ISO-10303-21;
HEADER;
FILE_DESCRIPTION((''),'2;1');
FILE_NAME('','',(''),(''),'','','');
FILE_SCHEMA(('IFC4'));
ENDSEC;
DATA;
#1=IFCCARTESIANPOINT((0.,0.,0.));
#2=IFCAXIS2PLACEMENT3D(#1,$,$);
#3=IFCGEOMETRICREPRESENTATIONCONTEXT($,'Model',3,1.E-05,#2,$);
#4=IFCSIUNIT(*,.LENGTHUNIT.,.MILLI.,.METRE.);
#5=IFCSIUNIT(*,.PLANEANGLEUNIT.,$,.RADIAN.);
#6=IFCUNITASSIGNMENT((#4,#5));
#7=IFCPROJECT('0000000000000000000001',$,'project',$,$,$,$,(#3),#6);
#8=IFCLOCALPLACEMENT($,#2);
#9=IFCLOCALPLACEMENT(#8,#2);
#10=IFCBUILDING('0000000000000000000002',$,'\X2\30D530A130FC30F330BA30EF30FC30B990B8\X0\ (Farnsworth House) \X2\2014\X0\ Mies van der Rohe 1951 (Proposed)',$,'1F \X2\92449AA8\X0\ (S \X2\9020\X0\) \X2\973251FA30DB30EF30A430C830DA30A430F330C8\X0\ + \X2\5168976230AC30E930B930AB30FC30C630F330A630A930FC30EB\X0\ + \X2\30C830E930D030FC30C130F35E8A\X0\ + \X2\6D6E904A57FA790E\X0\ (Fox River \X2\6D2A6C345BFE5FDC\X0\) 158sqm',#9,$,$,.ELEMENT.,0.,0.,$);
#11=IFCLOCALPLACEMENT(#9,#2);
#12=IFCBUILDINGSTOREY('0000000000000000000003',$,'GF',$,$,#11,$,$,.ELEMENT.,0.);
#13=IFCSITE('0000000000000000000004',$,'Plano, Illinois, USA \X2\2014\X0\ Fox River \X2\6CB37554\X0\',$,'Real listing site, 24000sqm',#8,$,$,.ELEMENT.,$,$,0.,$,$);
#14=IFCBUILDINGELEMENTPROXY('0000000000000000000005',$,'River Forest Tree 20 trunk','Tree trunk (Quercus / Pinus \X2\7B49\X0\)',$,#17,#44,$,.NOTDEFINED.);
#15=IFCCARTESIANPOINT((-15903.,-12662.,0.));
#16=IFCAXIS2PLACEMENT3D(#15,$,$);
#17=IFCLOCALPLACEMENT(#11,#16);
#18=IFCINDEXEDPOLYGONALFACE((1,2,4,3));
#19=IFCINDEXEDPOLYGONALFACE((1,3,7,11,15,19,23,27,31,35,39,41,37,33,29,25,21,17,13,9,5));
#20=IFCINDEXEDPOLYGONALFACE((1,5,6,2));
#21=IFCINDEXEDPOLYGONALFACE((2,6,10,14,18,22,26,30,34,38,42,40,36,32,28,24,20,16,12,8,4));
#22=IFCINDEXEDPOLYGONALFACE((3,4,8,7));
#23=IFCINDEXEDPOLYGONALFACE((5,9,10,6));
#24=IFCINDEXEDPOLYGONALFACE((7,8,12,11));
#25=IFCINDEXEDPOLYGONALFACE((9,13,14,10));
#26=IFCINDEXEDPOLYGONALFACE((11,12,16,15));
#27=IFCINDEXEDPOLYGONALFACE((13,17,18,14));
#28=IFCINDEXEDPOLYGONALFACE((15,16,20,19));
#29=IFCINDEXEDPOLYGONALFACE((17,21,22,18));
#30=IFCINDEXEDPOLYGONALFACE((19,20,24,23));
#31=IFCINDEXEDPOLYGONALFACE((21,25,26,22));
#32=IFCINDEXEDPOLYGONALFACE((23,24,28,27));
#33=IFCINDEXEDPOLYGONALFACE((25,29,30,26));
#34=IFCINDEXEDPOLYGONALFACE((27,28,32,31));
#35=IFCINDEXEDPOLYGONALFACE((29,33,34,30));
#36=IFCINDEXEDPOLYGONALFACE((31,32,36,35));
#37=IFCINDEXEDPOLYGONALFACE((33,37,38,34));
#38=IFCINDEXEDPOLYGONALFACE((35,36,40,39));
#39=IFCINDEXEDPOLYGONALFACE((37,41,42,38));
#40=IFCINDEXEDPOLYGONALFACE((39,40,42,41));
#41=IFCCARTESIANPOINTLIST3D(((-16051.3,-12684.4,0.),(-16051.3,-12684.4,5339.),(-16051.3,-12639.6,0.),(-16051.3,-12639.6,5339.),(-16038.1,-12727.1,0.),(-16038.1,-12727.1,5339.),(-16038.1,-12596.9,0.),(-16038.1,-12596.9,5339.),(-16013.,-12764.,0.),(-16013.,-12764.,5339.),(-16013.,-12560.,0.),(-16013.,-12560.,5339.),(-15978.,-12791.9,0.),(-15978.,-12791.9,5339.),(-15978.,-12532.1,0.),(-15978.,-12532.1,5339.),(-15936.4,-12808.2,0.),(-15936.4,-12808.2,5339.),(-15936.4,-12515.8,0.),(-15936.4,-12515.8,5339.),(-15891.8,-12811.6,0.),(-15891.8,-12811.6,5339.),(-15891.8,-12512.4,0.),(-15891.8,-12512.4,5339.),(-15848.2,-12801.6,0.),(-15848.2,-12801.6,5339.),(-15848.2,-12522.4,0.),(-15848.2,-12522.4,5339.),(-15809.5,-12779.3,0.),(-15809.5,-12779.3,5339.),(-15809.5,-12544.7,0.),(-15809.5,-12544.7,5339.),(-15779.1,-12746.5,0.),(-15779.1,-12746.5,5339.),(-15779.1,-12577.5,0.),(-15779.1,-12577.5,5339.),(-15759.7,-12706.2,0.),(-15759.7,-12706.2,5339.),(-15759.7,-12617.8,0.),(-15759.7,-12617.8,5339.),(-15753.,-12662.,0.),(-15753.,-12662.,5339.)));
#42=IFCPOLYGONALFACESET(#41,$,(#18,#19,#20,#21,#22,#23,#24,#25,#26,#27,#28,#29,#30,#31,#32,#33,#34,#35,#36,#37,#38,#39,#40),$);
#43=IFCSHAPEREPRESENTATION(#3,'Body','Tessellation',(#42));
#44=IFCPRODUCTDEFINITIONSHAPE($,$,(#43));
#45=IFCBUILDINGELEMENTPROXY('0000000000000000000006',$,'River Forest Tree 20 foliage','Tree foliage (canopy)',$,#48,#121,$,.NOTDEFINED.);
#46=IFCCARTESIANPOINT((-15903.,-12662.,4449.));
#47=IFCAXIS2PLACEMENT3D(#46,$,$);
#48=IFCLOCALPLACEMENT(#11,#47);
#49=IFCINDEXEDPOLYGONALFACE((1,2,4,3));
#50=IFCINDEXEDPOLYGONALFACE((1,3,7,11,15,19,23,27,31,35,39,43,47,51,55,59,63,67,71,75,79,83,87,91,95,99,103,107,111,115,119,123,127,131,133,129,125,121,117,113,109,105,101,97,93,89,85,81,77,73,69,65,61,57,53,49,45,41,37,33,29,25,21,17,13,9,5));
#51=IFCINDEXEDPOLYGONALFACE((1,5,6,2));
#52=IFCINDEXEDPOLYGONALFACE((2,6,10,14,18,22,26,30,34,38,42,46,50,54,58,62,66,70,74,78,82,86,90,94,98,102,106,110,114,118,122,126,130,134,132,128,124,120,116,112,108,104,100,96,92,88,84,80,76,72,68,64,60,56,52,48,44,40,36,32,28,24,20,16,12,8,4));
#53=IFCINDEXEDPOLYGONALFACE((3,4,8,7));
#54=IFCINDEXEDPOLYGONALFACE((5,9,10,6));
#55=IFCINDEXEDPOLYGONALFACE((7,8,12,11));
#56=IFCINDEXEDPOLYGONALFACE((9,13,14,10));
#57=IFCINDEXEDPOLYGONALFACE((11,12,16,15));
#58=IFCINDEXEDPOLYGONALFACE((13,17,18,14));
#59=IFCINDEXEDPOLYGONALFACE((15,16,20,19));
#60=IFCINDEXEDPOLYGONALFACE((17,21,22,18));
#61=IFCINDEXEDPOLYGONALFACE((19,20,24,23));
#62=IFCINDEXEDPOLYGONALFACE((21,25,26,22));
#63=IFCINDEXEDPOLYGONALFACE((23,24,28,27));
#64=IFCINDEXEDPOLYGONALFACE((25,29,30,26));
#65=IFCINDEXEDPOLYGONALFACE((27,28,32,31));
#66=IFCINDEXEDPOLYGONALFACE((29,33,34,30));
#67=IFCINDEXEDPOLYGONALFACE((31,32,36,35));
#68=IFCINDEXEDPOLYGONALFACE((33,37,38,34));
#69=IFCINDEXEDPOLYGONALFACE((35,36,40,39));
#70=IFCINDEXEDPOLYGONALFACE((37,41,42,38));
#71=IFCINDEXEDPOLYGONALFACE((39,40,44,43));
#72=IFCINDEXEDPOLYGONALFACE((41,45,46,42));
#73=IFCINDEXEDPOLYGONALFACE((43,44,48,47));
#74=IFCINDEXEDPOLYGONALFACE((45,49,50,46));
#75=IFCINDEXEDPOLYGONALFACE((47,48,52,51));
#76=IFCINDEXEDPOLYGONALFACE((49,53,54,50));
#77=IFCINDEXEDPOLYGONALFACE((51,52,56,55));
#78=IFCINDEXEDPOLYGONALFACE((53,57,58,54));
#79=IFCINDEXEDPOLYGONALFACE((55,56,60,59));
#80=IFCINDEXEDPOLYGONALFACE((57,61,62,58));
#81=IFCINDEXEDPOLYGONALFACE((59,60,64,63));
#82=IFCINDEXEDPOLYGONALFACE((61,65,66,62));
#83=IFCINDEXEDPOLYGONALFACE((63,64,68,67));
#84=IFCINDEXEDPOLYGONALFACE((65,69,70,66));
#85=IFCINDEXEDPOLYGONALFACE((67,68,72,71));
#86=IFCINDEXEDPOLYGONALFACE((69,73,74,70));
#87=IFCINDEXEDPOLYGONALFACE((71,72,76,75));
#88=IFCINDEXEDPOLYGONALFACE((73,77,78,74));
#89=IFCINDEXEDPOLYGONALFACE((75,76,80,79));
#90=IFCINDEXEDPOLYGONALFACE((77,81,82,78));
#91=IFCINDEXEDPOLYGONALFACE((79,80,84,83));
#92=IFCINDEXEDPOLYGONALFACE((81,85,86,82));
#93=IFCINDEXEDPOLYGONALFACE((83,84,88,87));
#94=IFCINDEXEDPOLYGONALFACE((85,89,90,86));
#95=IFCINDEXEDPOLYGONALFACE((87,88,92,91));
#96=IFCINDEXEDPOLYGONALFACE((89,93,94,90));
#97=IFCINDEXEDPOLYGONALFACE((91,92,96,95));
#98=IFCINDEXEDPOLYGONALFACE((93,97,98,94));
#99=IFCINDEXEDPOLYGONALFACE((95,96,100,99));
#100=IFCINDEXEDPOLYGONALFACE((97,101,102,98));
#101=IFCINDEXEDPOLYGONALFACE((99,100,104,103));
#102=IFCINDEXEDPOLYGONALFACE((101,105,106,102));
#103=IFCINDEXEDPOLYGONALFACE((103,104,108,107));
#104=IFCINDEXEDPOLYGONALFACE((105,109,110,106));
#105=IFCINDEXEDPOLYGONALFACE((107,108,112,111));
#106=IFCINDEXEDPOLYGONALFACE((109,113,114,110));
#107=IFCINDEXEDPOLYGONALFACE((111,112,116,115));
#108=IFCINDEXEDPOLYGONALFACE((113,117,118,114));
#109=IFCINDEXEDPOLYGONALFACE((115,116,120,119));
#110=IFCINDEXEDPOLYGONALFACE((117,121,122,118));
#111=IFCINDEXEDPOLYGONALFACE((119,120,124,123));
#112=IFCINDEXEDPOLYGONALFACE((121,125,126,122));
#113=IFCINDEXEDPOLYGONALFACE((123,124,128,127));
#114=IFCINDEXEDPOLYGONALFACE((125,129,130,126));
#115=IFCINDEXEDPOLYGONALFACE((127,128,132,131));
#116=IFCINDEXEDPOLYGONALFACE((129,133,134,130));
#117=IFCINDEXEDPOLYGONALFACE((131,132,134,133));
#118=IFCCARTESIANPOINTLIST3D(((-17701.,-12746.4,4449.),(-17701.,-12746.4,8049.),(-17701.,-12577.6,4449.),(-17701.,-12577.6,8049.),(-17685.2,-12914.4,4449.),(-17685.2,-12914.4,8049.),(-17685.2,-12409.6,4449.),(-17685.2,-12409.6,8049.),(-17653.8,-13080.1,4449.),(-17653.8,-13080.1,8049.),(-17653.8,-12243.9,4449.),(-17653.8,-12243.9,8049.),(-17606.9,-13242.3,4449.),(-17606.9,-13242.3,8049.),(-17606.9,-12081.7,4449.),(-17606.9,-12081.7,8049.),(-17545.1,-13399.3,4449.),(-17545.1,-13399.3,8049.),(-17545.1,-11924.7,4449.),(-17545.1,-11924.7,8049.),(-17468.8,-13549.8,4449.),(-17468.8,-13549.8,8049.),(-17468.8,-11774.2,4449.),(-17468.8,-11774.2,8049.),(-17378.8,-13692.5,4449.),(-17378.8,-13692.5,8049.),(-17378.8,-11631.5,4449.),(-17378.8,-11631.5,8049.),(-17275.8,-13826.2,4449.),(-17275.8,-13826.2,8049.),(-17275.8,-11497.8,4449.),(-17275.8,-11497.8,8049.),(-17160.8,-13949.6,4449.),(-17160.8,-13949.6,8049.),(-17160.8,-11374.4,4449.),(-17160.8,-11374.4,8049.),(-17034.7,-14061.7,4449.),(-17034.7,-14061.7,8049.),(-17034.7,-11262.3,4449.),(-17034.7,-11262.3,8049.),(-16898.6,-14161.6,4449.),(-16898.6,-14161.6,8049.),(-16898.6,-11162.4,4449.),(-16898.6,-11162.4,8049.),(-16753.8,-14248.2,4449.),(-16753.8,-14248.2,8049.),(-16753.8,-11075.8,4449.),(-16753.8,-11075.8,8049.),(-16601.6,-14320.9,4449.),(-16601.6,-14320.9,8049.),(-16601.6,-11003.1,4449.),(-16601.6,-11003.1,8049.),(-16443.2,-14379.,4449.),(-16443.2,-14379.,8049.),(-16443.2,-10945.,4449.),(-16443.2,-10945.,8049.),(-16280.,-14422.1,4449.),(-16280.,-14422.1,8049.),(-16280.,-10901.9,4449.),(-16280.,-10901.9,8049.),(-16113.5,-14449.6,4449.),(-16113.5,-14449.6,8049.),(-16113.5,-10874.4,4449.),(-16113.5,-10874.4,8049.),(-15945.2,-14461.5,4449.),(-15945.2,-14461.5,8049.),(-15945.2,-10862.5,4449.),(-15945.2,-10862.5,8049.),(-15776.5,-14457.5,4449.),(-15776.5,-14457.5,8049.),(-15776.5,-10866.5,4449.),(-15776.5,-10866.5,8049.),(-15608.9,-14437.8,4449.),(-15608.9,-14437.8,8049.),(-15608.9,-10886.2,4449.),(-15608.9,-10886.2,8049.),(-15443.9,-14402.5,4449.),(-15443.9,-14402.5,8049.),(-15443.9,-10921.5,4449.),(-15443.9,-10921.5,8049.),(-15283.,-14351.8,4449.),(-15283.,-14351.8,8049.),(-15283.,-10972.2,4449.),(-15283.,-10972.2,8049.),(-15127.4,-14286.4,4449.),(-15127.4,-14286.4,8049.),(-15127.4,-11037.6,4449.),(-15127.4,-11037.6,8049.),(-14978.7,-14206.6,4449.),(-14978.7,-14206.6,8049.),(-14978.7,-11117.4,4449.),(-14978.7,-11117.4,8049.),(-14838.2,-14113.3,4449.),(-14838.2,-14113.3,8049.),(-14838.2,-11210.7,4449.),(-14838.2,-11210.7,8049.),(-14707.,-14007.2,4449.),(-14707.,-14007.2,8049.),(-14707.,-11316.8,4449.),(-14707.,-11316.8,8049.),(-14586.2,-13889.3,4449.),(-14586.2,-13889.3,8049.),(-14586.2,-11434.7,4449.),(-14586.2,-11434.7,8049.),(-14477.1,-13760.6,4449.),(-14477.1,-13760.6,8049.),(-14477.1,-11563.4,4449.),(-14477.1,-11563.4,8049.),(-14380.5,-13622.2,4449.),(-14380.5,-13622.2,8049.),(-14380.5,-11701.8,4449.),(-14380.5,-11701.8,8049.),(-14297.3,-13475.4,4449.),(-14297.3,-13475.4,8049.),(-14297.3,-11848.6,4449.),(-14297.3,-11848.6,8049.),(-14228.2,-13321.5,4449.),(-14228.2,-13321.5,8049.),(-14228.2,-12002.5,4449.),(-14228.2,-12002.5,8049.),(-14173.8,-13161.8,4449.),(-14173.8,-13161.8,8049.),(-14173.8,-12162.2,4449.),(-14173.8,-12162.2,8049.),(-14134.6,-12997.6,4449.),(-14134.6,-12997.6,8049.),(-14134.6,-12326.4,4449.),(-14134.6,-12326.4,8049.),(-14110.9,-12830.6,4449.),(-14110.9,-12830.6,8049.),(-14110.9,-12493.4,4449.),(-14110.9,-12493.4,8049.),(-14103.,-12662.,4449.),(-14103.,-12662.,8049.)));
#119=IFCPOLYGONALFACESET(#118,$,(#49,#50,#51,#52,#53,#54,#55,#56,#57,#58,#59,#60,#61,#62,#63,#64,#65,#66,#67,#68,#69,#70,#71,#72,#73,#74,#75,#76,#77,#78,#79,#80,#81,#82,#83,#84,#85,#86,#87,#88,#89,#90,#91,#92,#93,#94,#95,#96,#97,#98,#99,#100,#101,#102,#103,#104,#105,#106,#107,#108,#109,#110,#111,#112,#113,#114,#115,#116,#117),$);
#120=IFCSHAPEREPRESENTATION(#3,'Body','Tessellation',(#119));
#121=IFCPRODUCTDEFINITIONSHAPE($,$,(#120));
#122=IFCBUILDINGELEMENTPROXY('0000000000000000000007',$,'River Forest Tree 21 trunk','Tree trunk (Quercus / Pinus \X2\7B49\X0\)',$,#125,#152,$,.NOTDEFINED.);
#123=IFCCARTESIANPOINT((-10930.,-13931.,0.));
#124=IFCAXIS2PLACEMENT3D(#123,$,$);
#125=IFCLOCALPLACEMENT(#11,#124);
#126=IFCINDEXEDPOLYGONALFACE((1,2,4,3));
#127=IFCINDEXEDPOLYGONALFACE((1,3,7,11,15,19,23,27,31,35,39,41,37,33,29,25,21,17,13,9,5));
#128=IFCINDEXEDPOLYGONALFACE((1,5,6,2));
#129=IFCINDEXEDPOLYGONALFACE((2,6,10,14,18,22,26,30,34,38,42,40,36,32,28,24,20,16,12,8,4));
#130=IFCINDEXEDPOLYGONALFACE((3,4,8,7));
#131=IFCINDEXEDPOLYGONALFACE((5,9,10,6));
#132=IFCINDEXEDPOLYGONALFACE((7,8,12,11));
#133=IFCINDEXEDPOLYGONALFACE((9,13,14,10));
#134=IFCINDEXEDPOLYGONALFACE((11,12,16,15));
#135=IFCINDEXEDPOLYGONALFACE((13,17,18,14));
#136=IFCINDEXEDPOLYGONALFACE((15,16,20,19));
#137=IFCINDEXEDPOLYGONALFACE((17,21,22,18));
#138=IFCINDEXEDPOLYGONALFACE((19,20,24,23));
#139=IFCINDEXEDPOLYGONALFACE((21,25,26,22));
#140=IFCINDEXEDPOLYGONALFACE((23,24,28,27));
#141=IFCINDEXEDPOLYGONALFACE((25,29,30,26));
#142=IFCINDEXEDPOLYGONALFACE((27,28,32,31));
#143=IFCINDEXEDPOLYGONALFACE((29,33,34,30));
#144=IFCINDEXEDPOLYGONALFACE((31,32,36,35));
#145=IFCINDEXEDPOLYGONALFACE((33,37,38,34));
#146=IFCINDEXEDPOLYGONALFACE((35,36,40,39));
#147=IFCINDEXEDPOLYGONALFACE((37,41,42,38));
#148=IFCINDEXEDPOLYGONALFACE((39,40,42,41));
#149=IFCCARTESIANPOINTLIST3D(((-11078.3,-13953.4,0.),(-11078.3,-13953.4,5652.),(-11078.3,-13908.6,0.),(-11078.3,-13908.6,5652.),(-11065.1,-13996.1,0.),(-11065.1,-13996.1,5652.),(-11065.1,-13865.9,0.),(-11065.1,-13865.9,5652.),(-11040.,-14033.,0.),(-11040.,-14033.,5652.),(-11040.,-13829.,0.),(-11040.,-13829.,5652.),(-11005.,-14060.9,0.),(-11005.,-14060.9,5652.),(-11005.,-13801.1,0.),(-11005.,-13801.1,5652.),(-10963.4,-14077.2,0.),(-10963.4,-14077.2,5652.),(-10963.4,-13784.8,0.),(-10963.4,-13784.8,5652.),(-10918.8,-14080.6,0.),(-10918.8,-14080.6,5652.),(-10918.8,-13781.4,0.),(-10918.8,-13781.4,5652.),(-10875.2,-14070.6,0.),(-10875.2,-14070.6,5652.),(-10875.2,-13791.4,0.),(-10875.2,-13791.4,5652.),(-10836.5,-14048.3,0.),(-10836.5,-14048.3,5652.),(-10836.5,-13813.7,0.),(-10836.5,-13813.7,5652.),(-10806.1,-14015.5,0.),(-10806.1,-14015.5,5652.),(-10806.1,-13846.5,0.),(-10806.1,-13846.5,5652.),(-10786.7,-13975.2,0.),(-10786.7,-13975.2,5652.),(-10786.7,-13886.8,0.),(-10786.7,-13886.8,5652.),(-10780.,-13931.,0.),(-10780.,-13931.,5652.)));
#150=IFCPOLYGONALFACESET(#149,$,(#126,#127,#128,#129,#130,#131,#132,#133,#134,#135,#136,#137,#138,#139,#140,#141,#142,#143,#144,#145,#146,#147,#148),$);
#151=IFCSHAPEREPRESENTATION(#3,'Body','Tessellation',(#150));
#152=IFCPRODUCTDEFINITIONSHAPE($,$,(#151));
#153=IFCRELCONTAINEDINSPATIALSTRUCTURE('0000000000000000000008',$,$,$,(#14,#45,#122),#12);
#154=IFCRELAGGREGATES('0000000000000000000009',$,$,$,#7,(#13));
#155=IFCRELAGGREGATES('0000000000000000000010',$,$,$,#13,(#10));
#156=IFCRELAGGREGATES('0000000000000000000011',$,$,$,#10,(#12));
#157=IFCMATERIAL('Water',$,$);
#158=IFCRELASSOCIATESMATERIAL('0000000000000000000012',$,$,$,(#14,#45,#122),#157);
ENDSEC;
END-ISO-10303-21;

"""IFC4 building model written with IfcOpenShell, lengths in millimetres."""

from ifc_helpers import new_model, si_unit, frame, origin, origin_2d, place, context, project, spatial, circle, extrude, material, element, save


model = new_model("IFC4")

# Units and contexts
model_context = context("Model", 3, precision=1e-05, world=origin())
ifc_project = project(units=[si_unit("LENGTHUNIT", "METRE", prefix="MILLI"), si_unit("PLANEANGLEUNIT", "RADIAN")], contexts=[model_context])

# Site, building, storey
site_placement = place(None, origin())
site = spatial("IfcSite", under=ifc_project, at=site_placement, Name="Plano, Illinois, USA — Fox River 河畔", ObjectType="Real listing site, 24000sqm", CompositionType="ELEMENT", RefElevation=0.0)
building_placement = place(site_placement, origin())
building = spatial("IfcBuilding", under=site, at=building_placement, Name="ファーンズワース邸 (Farnsworth House) — Mies van der Rohe 1951 (Proposed)", ObjectType="1F 鉄骨 (S 造) 露出ホワイトペイント + 全面ガラスカーテンウォール + トラバーチン床 + 浮遊基礎 (Fox River 洪水対応) 158sqm", CompositionType="ELEMENT", ElevationOfRefHeight=0.0, ElevationOfTerrain=0.0)
storey_placement = place(building_placement, origin())
storey = spatial("IfcBuildingStorey", under=building, at=storey_placement, Name="GF", CompositionType="ELEMENT", Elevation=0.0)

# Building element proxies
ifc_material_1 = material(Name="Water")
proxy_1_placement = place(storey_placement, frame((-15903.0, -12662.0, 0.0)))
element("IfcBuildingElementProxy", 1, at=proxy_1_placement, inside=storey, material=ifc_material_1, Name="River Forest Tree 20 trunk", Description="Tree trunk (Quercus / Pinus 等)", PredefinedType="NOTDEFINED", context=model_context, shape_type="SweptSolid", body=[
    extrude(circle(Radius=150.0, at=origin_2d()), frame((-15903.0, -12662.0, 0.0)), (0.0, 0.0, 1.0), 5339.0),
])
proxy_2_placement = place(storey_placement, frame((-15903.0, -12662.0, 4449.0)))
element("IfcBuildingElementProxy", 2, at=proxy_2_placement, inside=storey, material=ifc_material_1, Name="River Forest Tree 20 foliage", Description="Tree foliage (canopy)", PredefinedType="NOTDEFINED", context=model_context, shape_type="SweptSolid", body=[
    extrude(circle(Radius=1800.0, at=origin_2d()), frame((-15903.0, -12662.0, 4449.0)), (0.0, 0.0, 1.0), 3600.0),
])
proxy_3_placement = place(storey_placement, frame((-10930.0, -13931.0, 0.0)))
element("IfcBuildingElementProxy", 3, at=proxy_3_placement, inside=storey, material=ifc_material_1, Name="River Forest Tree 21 trunk", Description="Tree trunk (Quercus / Pinus 等)", PredefinedType="NOTDEFINED", context=model_context, shape_type="SweptSolid", body=[
    extrude(circle(Radius=150.0, at=origin_2d()), frame((-10930.0, -13931.0, 0.0)), (0.0, 0.0, 1.0), 5652.0),
])

save(model, "model.ifc")
